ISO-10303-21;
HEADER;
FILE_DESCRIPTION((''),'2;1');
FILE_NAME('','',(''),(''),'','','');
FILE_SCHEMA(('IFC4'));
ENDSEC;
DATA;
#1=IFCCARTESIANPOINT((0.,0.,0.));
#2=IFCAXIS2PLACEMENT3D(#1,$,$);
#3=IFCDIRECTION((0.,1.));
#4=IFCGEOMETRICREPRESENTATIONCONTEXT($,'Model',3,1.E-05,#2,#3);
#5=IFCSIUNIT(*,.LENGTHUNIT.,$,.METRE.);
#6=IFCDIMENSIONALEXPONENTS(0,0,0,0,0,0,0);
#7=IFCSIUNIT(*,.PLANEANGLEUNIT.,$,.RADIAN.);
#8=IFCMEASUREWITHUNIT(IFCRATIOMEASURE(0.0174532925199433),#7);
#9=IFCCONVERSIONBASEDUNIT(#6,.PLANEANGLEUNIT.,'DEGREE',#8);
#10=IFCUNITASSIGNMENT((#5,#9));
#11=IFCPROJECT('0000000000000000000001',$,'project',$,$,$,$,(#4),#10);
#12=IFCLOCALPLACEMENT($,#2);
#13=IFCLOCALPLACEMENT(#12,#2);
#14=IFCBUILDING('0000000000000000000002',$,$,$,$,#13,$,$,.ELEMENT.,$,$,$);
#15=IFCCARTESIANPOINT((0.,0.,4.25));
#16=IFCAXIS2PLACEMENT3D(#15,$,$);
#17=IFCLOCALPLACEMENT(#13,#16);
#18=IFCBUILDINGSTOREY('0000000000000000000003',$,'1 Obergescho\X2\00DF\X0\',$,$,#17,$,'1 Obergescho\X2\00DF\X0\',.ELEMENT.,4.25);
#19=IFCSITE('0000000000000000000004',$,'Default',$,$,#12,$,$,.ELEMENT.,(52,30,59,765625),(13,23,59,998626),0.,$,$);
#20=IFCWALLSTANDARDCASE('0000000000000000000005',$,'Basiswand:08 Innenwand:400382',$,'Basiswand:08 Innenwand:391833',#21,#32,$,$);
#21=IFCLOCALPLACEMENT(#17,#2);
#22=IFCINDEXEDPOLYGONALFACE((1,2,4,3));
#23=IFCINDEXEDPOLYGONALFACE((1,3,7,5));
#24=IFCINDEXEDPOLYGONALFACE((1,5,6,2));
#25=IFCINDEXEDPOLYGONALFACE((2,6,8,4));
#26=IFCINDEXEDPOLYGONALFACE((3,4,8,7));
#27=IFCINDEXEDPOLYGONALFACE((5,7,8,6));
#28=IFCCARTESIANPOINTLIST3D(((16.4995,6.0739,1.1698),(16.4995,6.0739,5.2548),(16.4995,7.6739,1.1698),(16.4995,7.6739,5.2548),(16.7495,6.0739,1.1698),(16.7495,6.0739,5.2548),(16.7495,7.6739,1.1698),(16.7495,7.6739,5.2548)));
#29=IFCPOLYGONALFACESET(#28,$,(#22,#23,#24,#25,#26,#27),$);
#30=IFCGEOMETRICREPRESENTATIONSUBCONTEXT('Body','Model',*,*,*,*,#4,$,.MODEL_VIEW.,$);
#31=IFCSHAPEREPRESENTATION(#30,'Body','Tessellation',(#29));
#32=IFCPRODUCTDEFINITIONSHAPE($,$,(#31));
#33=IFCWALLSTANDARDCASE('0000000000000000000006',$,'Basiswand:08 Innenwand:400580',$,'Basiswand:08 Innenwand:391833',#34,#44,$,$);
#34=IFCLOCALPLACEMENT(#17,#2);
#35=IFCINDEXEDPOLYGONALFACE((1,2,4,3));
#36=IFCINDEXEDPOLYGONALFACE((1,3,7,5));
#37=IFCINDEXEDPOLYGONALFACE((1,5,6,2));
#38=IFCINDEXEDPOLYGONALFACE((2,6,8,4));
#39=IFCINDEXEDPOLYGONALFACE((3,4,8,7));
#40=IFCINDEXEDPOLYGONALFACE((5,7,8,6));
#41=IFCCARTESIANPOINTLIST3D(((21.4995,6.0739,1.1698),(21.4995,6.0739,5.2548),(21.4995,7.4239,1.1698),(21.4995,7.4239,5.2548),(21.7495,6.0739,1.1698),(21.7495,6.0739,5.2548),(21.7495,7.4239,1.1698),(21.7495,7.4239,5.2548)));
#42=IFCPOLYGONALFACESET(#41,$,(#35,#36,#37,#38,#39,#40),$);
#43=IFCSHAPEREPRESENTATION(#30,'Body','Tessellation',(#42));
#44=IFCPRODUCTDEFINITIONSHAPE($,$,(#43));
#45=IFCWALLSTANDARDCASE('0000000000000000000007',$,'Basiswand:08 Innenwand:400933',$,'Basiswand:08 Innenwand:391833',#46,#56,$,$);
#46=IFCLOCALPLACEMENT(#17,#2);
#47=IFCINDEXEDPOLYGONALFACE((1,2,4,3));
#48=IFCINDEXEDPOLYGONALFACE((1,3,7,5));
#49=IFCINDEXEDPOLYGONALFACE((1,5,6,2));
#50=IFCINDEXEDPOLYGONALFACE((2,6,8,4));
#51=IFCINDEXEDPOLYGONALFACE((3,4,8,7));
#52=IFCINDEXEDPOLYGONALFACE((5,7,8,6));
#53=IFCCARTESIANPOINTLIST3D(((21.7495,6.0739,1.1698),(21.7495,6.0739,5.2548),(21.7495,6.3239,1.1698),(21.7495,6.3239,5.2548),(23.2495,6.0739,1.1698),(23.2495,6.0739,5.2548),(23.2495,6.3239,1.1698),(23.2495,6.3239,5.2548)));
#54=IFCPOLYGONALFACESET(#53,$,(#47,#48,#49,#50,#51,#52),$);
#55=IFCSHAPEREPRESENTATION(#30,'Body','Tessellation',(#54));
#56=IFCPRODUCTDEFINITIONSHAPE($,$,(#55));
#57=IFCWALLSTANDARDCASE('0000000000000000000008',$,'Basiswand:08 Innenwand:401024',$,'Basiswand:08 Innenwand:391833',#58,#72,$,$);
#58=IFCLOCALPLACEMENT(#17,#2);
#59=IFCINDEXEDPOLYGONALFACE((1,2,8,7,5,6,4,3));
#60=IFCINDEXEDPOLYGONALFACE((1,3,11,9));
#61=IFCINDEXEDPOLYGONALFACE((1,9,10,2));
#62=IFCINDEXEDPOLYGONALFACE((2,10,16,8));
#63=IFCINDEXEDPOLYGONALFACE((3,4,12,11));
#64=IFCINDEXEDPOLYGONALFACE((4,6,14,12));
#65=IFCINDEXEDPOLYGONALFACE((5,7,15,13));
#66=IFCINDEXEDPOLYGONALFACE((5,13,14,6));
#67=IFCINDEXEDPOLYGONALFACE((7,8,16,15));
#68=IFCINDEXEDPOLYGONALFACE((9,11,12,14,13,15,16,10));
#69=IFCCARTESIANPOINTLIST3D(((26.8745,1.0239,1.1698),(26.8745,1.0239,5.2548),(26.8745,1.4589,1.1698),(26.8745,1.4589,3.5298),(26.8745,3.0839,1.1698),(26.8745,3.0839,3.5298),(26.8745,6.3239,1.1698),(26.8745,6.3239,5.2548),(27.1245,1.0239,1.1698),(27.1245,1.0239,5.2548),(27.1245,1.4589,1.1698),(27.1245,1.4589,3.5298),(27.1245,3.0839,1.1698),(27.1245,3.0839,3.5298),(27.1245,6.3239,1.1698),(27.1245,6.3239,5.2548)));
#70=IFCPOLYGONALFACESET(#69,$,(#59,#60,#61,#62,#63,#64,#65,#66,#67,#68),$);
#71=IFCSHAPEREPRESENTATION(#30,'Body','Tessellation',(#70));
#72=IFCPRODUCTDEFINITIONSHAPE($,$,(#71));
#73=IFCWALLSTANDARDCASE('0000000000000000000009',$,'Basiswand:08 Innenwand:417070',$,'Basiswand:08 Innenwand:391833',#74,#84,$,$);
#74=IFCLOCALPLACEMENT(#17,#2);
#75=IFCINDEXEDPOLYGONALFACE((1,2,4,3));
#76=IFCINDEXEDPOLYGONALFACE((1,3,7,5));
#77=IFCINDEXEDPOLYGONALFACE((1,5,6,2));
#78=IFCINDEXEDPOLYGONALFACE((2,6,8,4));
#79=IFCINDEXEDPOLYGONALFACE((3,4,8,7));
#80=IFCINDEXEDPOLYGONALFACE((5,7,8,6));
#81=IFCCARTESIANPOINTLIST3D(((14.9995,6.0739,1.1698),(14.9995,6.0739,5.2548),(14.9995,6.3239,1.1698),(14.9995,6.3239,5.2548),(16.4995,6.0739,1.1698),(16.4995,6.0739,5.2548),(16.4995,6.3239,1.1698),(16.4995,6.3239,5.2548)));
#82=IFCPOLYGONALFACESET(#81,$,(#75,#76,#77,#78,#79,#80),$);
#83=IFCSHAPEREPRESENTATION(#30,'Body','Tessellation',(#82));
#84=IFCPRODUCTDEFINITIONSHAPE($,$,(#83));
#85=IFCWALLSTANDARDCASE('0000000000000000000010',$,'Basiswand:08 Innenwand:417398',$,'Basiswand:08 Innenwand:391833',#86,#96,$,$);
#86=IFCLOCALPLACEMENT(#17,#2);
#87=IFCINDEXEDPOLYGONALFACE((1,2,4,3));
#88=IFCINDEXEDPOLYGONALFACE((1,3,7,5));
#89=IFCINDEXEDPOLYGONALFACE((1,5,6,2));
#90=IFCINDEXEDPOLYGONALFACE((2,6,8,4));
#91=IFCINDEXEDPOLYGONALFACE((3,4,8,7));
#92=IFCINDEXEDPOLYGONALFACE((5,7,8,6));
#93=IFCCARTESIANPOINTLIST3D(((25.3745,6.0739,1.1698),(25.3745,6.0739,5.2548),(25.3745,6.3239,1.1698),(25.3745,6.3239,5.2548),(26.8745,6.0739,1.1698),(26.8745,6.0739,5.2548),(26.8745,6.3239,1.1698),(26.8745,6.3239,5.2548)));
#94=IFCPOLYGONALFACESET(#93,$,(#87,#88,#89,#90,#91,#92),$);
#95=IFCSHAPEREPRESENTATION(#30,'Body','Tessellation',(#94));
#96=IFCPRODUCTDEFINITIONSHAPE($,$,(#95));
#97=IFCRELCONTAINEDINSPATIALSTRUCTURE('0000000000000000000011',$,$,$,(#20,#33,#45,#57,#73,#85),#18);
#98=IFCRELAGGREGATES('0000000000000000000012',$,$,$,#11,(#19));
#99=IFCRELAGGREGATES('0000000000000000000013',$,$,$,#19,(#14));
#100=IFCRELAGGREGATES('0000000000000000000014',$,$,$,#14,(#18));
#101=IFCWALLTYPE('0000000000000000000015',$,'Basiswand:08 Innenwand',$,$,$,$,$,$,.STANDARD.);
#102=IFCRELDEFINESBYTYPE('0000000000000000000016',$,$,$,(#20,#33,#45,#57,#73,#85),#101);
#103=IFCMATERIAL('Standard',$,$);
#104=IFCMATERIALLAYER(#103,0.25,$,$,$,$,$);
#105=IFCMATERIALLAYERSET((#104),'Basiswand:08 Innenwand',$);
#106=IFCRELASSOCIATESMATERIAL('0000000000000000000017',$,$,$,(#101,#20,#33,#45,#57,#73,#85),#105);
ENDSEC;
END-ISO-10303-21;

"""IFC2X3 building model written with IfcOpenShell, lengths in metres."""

from ifc_helpers import new_model, entity, si_unit, converted_unit, direction, frame, frame_2d, origin, place, context, subcontext, project, spatial, polyline, rectangle, extrude, clip, bounded_halfspace, material, layer, layer_set, layer_usage, type_object, element, save


model = new_model("IFC2X3")

# Units and contexts
model_context = context("Model", 3, precision=1e-05, world=origin(), true_north=direction((0.0, 1.0)))
body_context = subcontext(model_context, "Body", "Model", "MODEL_VIEW")
ifc_project = project(units=[si_unit("LENGTHUNIT", "METRE"), converted_unit("PLANEANGLEUNIT", "DEGREE", entity("IfcRatioMeasure", 0.0174532925199433), si_unit("PLANEANGLEUNIT", "RADIAN"), dimensions=[0, 0, 0, 0, 0, 0, 0])], contexts=[model_context])

# Site, building, storey
site_placement = place(None, origin())
site = spatial("IfcSite", under=ifc_project, at=site_placement, Name="Default", CompositionType="ELEMENT", RefLatitude=(52, 30, 59, 765625), RefLongitude=(13, 23, 59, 998626), RefElevation=0.0)
building_placement = place(site_placement, origin())
building = spatial("IfcBuilding", under=site, at=building_placement, CompositionType="ELEMENT")
storey_placement = place(building_placement, frame((0.0, 0.0, 4.25)))
storey = spatial("IfcBuildingStorey", under=building, at=storey_placement, Name="1 Obergeschoß", LongName="1 Obergeschoß", CompositionType="ELEMENT", Elevation=4.25)

# Shared definitions
ifc_material_1 = material(Name="Standard")
ifc_layer_1 = layer(ifc_material_1, 0.25)
ifc_layer_set_1 = layer_set([ifc_layer_1], Name="Basiswand:08 Innenwand")
wall_type_1 = type_object("IfcWallType", Name="Basiswand:08 Innenwand", PredefinedType="STANDARD", material=ifc_layer_set_1)

# Walls
ifc_layer_usage_1 = layer_usage(ifc_layer_set_1, "AXIS2", "NEGATIVE", 0.125)
wall_1_placement = place(storey_placement, frame((16.6245, 6.0739, 1.1698), z_axis=(0.0, 0.0, 1.0), x_axis=(0.0, 1.0, 0.0)))
element("IfcWallStandardCase", 1, at=wall_1_placement, inside=storey, type_object=wall_type_1, material=ifc_layer_usage_1, Name="Basiswand:08 Innenwand:400382", ObjectType="Basiswand:08 Innenwand:391833", context=body_context, shape_type="Clipping", body=[
    clip(extrude(rectangle(XDim=1.6, YDim=0.25, at=frame_2d((0.8, 0.0), x_axis=(-1.0, 0.0))), origin(), (0.0, 0.0, 1.0), 4.085), bounded_halfspace(frame((0.0, -0.125, 4.085), z_axis=(0.0, 0.0, -1.0), x_axis=(-1.0, 0.0, 0.0)), True, frame((0.0, -0.125, 4.085)), polyline([(0.0, 0.0), (1.35, 0.0), (1.6, 0.0), (1.6, 0.25), (0.25, 0.25), (0.0, 0.25), (0.0, 0.0)]))),
])
ifc_layer_usage_2 = layer_usage(ifc_layer_set_1, "AXIS2", "NEGATIVE", 0.125)
wall_2_placement = place(storey_placement, frame((21.6245, 7.4239, 1.1698), z_axis=(0.0, 0.0, 1.0), x_axis=(0.0, -1.0, 0.0)))
element("IfcWallStandardCase", 2, at=wall_2_placement, inside=storey, type_object=wall_type_1, material=ifc_layer_usage_2, Name="Basiswand:08 Innenwand:400580", ObjectType="Basiswand:08 Innenwand:391833", context=body_context, shape_type="Clipping", body=[
    clip(extrude(rectangle(XDim=1.35, YDim=0.25, at=frame_2d((0.675, 0.0), x_axis=(-1.0, 0.0))), origin(), (0.0, 0.0, 1.0), 4.085), bounded_halfspace(frame((0.0, -0.125, 4.085), z_axis=(0.0, 0.0, -1.0), x_axis=(1.0, 0.0, 0.0)), True, frame((0.0, -0.125, 4.085)), polyline([(0.0, 0.0), (1.35, 0.0), (1.35, 0.25), (1.1, 0.25), (0.0, 0.25), (0.0, 0.0)]))),
])
ifc_layer_usage_3 = layer_usage(ifc_layer_set_1, "AXIS2", "NEGATIVE", 0.125)
wall_3_placement = place(storey_placement, frame((21.7495, 6.1989, 1.1698), z_axis=(0.0, 0.0, 1.0), x_axis=(1.0, 0.0, 0.0)))
element("IfcWallStandardCase", 3, at=wall_3_placement, inside=storey, type_object=wall_type_1, material=ifc_layer_usage_3, Name="Basiswand:08 Innenwand:400933", ObjectType="Basiswand:08 Innenwand:391833", context=body_context, shape_type="Clipping", body=[
    clip(extrude(rectangle(XDim=1.5, YDim=0.25, at=frame_2d((0.75, 0.0), x_axis=(-1.0, 0.0))), origin(), (0.0, 0.0, 1.0), 4.085), bounded_halfspace(frame((0.0, -0.125, 4.085), z_axis=(0.0, 0.0, -1.0), x_axis=(0.0, -1.0, 0.0)), True, frame((0.0, -0.125, 4.085)), polyline([(0.0, 0.0), (1.5, 0.0), (1.5, 0.25), (1.4, 0.25), (0.0, 0.25), (0.0, 0.0)]))),
])

# Wall, opening
ifc_layer_usage_4 = layer_usage(ifc_layer_set_1, "AXIS2", "NEGATIVE", 0.125)
wall_4_placement = place(storey_placement, frame((26.9995, 6.3239, 1.1698), z_axis=(0.0, 0.0, 1.0), x_axis=(0.0, -1.0, 0.0)))
wall_4 = element("IfcWallStandardCase", 4, at=wall_4_placement, inside=storey, type_object=wall_type_1, material=ifc_layer_usage_4, Name="Basiswand:08 Innenwand:401024", ObjectType="Basiswand:08 Innenwand:391833", context=body_context, shape_type="Clipping", body=[
    clip(extrude(rectangle(XDim=5.3, YDim=0.25, at=frame_2d((2.65, 0.0), x_axis=(-1.0, 0.0))), origin(), (0.0, 0.0, 1.0), 4.085), bounded_halfspace(frame((0.0, -0.125, 4.085), z_axis=(0.0, 0.0, -1.0), x_axis=(1.0, 0.0, 0.0)), True, frame((0.0, -0.125, 4.085)), polyline([(0.0, 0.0), (0.25, 0.0), (5.3, 0.0), (5.3, 0.25), (0.0, 0.25), (0.0, 0.0)]))),
])
opening_1_placement = place(wall_4_placement, frame((4.865, 0.125, 0.0)))
element("IfcOpeningElement", 5, at=opening_1_placement, cuts=wall_4, ObjectType="Opening", context=body_context, shape_type="SweptSolid", body=[
    extrude(rectangle(XDim=2.36, YDim=1.625, at=frame_2d((1.18, 0.8125), x_axis=(1.0, 0.0))), frame((0.0, 0.0, 0.0), z_axis=(0.0, -1.0, 0.0), x_axis=(0.0, 0.0, 1.0)), (0.0, 0.0, 1.0), 0.25),
])

# Walls
ifc_layer_usage_5 = layer_usage(ifc_layer_set_1, "AXIS2", "POSITIVE", -0.125)
wall_5_placement = place(storey_placement, frame((16.4995, 6.1989, 1.1698), z_axis=(0.0, 0.0, 1.0), x_axis=(-1.0, 0.0, 0.0)))
element("IfcWallStandardCase", 6, at=wall_5_placement, inside=storey, type_object=wall_type_1, material=ifc_layer_usage_5, Name="Basiswand:08 Innenwand:417070", ObjectType="Basiswand:08 Innenwand:391833", context=body_context, shape_type="Clipping", body=[
    clip(extrude(rectangle(XDim=1.5, YDim=0.25, at=frame_2d((0.75, 0.0), x_axis=(-1.0, 0.0))), origin(), (0.0, 0.0, 1.0), 4.085), bounded_halfspace(frame((0.0, -0.125, 4.085), z_axis=(0.0, 0.0, -1.0), x_axis=(0.0, 1.0, 0.0)), True, frame((0.0, -0.125, 4.085)), polyline([(0.0, 0.0), (1.4, 0.0), (1.5, 0.0), (1.5, 0.25), (0.0, 0.25), (0.0, 0.0)]))),
])
ifc_layer_usage_6 = layer_usage(ifc_layer_set_1, "AXIS2", "NEGATIVE", 0.125)
wall_6_placement = place(storey_placement, frame((25.3745, 6.1989, 1.1698), z_axis=(0.0, 0.0, 1.0), x_axis=(1.0, 0.0, 0.0)))
element("IfcWallStandardCase", 7, at=wall_6_placement, inside=storey, type_object=wall_type_1, material=ifc_layer_usage_6, Name="Basiswand:08 Innenwand:417398", ObjectType="Basiswand:08 Innenwand:391833", context=body_context, shape_type="Clipping", body=[
    clip(extrude(rectangle(XDim=1.5, YDim=0.25, at=frame_2d((0.75, 0.0), x_axis=(-1.0, 0.0))), origin(), (0.0, 0.0, 1.0), 4.085), bounded_halfspace(frame((0.0, -0.125, 4.085), z_axis=(0.0, 0.0, -1.0), x_axis=(0.0, -1.0, 0.0)), True, frame((0.0, -0.125, 4.085)), polyline([(0.0, 0.0), (1.5, 0.0), (1.5, 0.25), (0.1, 0.25), (0.0, 0.25), (0.0, 0.0)]))),
])

save(model, "model.ifc")
